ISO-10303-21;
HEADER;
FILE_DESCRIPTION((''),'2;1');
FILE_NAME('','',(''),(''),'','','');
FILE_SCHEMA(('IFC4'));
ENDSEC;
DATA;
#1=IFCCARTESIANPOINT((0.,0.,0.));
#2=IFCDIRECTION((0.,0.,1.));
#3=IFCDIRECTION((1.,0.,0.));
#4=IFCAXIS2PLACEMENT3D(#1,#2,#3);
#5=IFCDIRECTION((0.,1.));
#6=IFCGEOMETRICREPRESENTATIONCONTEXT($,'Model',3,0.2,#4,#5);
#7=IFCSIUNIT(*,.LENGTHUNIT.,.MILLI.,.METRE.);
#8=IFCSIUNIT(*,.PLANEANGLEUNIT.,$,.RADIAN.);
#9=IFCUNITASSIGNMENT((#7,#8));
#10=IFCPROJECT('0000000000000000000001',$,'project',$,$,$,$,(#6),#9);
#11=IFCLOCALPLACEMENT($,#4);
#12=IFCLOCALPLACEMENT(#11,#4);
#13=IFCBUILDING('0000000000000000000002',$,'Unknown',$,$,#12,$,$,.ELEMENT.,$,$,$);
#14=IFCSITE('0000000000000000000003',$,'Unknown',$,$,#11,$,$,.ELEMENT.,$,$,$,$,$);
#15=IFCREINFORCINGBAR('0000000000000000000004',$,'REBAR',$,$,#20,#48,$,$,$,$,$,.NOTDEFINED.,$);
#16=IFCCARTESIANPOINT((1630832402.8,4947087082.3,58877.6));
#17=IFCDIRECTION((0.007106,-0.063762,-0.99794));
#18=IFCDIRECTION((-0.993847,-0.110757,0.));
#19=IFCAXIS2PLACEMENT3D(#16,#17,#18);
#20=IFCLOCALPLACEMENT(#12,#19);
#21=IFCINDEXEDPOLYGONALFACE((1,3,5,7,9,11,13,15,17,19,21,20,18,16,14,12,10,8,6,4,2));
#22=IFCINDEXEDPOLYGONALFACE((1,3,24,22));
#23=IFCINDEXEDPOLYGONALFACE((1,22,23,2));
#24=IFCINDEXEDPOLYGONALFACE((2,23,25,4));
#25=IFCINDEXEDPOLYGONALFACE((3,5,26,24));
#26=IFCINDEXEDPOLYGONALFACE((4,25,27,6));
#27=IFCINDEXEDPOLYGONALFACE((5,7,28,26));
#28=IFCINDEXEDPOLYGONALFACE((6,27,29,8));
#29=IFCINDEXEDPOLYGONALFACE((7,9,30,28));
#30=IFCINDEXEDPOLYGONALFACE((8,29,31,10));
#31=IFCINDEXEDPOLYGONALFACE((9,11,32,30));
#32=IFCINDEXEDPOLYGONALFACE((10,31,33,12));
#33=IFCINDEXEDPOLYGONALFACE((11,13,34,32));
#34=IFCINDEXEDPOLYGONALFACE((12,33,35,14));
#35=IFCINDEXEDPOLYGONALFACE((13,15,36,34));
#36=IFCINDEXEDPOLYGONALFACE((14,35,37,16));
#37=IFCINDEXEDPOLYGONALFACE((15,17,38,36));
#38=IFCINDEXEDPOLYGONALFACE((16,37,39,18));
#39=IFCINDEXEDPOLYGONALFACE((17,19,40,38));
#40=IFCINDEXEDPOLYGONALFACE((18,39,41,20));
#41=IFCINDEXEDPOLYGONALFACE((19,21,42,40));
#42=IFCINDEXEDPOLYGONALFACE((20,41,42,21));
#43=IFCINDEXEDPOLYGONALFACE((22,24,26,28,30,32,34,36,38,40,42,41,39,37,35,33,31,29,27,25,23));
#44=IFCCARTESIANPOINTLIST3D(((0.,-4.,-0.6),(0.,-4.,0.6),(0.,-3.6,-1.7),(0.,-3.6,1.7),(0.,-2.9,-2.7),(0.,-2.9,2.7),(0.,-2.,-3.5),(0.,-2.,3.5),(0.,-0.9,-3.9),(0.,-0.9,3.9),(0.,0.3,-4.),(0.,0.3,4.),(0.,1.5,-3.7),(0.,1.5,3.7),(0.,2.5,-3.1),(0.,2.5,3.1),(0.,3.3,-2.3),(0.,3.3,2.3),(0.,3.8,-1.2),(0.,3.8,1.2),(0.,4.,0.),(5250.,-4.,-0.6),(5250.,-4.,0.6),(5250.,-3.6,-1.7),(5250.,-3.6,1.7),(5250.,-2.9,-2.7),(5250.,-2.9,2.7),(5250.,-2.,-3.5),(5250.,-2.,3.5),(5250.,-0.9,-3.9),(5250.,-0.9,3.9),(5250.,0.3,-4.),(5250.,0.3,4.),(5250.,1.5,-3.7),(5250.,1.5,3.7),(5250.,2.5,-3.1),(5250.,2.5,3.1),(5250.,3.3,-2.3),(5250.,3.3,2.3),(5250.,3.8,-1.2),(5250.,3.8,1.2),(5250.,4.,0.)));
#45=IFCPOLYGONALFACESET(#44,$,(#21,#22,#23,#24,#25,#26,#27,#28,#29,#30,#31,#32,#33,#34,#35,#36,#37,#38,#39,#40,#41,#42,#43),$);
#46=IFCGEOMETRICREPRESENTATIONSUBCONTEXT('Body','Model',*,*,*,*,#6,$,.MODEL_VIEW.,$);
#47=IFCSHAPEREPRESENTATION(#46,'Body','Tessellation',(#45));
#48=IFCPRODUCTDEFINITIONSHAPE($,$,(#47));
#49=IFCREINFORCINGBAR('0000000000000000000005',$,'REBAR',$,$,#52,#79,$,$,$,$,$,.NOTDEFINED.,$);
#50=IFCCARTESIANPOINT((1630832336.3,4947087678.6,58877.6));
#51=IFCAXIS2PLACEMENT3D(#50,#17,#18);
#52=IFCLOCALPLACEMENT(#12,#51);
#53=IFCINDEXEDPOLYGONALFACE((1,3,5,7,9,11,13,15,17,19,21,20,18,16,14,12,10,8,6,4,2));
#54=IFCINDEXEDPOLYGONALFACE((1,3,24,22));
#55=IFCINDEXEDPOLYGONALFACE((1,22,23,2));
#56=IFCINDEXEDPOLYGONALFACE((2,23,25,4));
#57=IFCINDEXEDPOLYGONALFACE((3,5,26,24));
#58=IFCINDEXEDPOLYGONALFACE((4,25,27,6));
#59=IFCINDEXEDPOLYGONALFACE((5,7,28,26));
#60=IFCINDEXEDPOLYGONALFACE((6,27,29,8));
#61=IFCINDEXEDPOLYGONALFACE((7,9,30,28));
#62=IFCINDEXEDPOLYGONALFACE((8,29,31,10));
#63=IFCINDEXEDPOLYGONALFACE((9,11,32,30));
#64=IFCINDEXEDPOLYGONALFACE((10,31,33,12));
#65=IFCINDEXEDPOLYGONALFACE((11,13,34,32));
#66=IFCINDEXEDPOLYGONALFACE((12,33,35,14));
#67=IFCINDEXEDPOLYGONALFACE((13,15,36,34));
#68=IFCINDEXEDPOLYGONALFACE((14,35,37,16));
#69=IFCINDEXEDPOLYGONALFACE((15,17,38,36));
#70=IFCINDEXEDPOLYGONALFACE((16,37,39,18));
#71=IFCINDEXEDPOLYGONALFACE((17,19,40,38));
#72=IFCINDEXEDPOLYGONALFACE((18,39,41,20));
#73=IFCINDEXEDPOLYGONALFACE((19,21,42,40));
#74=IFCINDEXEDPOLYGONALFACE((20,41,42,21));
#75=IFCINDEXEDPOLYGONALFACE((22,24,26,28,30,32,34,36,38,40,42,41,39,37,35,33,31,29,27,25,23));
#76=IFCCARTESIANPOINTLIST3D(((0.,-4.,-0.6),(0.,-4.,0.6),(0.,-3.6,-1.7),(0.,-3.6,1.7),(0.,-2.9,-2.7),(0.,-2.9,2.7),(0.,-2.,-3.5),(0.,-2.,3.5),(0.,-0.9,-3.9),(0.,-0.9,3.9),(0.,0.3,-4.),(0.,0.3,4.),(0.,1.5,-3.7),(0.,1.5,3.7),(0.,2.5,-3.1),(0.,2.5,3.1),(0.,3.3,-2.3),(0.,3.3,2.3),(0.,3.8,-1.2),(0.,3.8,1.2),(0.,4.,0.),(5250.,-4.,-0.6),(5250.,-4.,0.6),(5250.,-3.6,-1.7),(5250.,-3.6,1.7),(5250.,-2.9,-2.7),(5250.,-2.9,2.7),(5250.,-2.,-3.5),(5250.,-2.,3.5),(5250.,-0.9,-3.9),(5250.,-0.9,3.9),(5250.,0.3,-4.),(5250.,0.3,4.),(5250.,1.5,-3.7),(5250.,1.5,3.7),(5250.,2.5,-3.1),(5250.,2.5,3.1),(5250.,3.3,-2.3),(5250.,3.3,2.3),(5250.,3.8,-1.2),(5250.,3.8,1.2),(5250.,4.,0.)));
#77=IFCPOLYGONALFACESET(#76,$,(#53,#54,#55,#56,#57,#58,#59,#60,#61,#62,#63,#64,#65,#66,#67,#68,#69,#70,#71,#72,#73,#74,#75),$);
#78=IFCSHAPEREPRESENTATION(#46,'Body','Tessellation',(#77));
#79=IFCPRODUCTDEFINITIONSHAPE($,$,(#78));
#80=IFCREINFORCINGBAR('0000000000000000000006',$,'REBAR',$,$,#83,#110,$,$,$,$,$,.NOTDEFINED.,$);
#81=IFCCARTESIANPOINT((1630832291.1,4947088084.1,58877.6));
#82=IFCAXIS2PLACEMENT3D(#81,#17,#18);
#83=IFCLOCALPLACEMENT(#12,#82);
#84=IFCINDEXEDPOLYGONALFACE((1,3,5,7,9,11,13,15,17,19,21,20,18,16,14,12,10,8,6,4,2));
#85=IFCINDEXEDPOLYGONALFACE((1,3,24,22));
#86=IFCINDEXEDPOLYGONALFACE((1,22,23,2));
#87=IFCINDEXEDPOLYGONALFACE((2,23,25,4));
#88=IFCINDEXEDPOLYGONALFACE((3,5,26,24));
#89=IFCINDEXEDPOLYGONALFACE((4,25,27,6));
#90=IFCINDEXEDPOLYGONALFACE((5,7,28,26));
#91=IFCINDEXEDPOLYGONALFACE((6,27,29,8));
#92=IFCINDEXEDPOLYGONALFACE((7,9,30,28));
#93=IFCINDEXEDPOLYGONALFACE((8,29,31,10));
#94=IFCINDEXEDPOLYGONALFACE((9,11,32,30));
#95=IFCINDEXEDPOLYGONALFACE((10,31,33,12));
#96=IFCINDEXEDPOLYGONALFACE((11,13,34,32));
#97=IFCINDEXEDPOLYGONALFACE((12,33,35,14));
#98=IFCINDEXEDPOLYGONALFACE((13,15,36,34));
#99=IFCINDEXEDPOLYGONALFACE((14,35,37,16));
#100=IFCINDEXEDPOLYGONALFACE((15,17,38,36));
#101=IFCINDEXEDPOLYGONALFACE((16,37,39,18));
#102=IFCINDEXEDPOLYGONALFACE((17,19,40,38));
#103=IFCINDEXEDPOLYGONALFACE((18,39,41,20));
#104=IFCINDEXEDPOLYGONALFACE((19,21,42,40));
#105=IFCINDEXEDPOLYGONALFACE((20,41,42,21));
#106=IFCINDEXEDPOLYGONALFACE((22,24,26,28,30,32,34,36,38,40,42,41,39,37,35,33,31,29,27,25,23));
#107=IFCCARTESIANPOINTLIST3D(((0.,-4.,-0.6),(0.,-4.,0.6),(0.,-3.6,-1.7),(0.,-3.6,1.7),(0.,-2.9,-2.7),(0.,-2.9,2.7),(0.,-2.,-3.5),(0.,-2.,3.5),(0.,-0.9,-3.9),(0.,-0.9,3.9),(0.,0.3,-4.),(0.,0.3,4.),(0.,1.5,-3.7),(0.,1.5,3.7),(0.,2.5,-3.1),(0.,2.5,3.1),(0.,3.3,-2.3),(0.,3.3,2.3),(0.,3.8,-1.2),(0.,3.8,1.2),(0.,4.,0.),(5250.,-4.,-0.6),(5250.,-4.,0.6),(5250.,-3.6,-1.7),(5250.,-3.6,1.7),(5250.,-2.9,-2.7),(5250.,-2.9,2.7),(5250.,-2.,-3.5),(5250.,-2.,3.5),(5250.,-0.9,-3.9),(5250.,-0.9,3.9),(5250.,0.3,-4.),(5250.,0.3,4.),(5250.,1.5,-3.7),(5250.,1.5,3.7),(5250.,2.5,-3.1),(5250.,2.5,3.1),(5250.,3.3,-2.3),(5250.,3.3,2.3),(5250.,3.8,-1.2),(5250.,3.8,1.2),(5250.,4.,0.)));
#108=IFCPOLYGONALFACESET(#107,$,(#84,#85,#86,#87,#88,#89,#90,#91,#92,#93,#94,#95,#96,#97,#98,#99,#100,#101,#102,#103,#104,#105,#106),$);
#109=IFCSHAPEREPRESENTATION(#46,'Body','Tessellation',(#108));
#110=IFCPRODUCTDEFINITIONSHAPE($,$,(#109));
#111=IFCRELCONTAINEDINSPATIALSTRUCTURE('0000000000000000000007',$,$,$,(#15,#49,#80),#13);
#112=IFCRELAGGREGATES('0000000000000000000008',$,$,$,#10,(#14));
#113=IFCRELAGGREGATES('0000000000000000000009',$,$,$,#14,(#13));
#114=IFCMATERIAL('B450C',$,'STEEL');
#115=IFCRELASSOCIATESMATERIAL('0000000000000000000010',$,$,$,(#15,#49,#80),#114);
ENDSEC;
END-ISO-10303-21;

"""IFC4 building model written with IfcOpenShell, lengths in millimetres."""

from ifc_helpers import new_model, entity, si_unit, direction, frame, origin_with_axes, place, context, subcontext, project, spatial, material, element, save


model = new_model("IFC4")

# Units and contexts
model_context = context("Model", 3, precision=0.2, world=origin_with_axes(), true_north=direction((0.0, 1.0)))
body_context = subcontext(model_context, "Body", "Model", "MODEL_VIEW")
ifc_project = project(units=[si_unit("LENGTHUNIT", "METRE", prefix="MILLI"), si_unit("PLANEANGLEUNIT", "RADIAN")], contexts=[model_context])

# Site, building
site_placement = place(None, origin_with_axes())
site = spatial("IfcSite", under=ifc_project, at=site_placement, Name="Unknown", CompositionType="ELEMENT")
building_placement = place(site_placement, origin_with_axes())
building = spatial("IfcBuilding", under=site, at=building_placement, Name="Unknown", CompositionType="ELEMENT")

# Reinforcing bars
ifc_material = material(Name="B450C", Category="STEEL")
reinforcing_bar_1_placement = place(building_placement, frame((1630832402.8, 4947087082.3, 58877.6), z_axis=(0.007106, -0.063762, -0.99794), x_axis=(-0.993847, -0.110757, 0.0)))
element("IfcReinforcingBar", 1, at=reinforcing_bar_1_placement, inside=building, material=ifc_material, Name="REBAR", PredefinedType="NOTDEFINED", context=body_context, shape_type="AdvancedSweptSolid", body=[
    entity("IfcSweptDiskSolid", entity("IfcIndexedPolyCurve", entity("IfcCartesianPointList3D", [[0.0, 0.0, 0.0], [5250.0, 0.0, 0.0]]), [entity("IfcLineIndex", [1, 2])]), 4.0),
])
reinforcing_bar_2_placement = place(building_placement, frame((1630832336.3, 4947087678.6, 58877.6), z_axis=(0.007106, -0.063762, -0.99794), x_axis=(-0.993847, -0.110757, 0.0)))
element("IfcReinforcingBar", 2, at=reinforcing_bar_2_placement, inside=building, material=ifc_material, Name="REBAR", PredefinedType="NOTDEFINED", context=body_context, shape_type="AdvancedSweptSolid", body=[
    entity("IfcSweptDiskSolid", entity("IfcIndexedPolyCurve", entity("IfcCartesianPointList3D", [[0.0, 0.0, 0.0], [5250.0, 0.0, 0.0]]), [entity("IfcLineIndex", [1, 2])]), 4.0),
])
reinforcing_bar_3_placement = place(building_placement, frame((1630832291.1, 4947088084.1, 58877.6), z_axis=(0.007106, -0.063762, -0.99794), x_axis=(-0.993847, -0.110757, 0.0)))
element("IfcReinforcingBar", 3, at=reinforcing_bar_3_placement, inside=building, material=ifc_material, Name="REBAR", PredefinedType="NOTDEFINED", context=body_context, shape_type="AdvancedSweptSolid", body=[
    entity("IfcSweptDiskSolid", entity("IfcIndexedPolyCurve", entity("IfcCartesianPointList3D", [[0.0, 0.0, 0.0], [5250.0, 0.0, 0.0]]), [entity("IfcLineIndex", [1, 2])]), 4.0),
])

save(model, "model.ifc")
